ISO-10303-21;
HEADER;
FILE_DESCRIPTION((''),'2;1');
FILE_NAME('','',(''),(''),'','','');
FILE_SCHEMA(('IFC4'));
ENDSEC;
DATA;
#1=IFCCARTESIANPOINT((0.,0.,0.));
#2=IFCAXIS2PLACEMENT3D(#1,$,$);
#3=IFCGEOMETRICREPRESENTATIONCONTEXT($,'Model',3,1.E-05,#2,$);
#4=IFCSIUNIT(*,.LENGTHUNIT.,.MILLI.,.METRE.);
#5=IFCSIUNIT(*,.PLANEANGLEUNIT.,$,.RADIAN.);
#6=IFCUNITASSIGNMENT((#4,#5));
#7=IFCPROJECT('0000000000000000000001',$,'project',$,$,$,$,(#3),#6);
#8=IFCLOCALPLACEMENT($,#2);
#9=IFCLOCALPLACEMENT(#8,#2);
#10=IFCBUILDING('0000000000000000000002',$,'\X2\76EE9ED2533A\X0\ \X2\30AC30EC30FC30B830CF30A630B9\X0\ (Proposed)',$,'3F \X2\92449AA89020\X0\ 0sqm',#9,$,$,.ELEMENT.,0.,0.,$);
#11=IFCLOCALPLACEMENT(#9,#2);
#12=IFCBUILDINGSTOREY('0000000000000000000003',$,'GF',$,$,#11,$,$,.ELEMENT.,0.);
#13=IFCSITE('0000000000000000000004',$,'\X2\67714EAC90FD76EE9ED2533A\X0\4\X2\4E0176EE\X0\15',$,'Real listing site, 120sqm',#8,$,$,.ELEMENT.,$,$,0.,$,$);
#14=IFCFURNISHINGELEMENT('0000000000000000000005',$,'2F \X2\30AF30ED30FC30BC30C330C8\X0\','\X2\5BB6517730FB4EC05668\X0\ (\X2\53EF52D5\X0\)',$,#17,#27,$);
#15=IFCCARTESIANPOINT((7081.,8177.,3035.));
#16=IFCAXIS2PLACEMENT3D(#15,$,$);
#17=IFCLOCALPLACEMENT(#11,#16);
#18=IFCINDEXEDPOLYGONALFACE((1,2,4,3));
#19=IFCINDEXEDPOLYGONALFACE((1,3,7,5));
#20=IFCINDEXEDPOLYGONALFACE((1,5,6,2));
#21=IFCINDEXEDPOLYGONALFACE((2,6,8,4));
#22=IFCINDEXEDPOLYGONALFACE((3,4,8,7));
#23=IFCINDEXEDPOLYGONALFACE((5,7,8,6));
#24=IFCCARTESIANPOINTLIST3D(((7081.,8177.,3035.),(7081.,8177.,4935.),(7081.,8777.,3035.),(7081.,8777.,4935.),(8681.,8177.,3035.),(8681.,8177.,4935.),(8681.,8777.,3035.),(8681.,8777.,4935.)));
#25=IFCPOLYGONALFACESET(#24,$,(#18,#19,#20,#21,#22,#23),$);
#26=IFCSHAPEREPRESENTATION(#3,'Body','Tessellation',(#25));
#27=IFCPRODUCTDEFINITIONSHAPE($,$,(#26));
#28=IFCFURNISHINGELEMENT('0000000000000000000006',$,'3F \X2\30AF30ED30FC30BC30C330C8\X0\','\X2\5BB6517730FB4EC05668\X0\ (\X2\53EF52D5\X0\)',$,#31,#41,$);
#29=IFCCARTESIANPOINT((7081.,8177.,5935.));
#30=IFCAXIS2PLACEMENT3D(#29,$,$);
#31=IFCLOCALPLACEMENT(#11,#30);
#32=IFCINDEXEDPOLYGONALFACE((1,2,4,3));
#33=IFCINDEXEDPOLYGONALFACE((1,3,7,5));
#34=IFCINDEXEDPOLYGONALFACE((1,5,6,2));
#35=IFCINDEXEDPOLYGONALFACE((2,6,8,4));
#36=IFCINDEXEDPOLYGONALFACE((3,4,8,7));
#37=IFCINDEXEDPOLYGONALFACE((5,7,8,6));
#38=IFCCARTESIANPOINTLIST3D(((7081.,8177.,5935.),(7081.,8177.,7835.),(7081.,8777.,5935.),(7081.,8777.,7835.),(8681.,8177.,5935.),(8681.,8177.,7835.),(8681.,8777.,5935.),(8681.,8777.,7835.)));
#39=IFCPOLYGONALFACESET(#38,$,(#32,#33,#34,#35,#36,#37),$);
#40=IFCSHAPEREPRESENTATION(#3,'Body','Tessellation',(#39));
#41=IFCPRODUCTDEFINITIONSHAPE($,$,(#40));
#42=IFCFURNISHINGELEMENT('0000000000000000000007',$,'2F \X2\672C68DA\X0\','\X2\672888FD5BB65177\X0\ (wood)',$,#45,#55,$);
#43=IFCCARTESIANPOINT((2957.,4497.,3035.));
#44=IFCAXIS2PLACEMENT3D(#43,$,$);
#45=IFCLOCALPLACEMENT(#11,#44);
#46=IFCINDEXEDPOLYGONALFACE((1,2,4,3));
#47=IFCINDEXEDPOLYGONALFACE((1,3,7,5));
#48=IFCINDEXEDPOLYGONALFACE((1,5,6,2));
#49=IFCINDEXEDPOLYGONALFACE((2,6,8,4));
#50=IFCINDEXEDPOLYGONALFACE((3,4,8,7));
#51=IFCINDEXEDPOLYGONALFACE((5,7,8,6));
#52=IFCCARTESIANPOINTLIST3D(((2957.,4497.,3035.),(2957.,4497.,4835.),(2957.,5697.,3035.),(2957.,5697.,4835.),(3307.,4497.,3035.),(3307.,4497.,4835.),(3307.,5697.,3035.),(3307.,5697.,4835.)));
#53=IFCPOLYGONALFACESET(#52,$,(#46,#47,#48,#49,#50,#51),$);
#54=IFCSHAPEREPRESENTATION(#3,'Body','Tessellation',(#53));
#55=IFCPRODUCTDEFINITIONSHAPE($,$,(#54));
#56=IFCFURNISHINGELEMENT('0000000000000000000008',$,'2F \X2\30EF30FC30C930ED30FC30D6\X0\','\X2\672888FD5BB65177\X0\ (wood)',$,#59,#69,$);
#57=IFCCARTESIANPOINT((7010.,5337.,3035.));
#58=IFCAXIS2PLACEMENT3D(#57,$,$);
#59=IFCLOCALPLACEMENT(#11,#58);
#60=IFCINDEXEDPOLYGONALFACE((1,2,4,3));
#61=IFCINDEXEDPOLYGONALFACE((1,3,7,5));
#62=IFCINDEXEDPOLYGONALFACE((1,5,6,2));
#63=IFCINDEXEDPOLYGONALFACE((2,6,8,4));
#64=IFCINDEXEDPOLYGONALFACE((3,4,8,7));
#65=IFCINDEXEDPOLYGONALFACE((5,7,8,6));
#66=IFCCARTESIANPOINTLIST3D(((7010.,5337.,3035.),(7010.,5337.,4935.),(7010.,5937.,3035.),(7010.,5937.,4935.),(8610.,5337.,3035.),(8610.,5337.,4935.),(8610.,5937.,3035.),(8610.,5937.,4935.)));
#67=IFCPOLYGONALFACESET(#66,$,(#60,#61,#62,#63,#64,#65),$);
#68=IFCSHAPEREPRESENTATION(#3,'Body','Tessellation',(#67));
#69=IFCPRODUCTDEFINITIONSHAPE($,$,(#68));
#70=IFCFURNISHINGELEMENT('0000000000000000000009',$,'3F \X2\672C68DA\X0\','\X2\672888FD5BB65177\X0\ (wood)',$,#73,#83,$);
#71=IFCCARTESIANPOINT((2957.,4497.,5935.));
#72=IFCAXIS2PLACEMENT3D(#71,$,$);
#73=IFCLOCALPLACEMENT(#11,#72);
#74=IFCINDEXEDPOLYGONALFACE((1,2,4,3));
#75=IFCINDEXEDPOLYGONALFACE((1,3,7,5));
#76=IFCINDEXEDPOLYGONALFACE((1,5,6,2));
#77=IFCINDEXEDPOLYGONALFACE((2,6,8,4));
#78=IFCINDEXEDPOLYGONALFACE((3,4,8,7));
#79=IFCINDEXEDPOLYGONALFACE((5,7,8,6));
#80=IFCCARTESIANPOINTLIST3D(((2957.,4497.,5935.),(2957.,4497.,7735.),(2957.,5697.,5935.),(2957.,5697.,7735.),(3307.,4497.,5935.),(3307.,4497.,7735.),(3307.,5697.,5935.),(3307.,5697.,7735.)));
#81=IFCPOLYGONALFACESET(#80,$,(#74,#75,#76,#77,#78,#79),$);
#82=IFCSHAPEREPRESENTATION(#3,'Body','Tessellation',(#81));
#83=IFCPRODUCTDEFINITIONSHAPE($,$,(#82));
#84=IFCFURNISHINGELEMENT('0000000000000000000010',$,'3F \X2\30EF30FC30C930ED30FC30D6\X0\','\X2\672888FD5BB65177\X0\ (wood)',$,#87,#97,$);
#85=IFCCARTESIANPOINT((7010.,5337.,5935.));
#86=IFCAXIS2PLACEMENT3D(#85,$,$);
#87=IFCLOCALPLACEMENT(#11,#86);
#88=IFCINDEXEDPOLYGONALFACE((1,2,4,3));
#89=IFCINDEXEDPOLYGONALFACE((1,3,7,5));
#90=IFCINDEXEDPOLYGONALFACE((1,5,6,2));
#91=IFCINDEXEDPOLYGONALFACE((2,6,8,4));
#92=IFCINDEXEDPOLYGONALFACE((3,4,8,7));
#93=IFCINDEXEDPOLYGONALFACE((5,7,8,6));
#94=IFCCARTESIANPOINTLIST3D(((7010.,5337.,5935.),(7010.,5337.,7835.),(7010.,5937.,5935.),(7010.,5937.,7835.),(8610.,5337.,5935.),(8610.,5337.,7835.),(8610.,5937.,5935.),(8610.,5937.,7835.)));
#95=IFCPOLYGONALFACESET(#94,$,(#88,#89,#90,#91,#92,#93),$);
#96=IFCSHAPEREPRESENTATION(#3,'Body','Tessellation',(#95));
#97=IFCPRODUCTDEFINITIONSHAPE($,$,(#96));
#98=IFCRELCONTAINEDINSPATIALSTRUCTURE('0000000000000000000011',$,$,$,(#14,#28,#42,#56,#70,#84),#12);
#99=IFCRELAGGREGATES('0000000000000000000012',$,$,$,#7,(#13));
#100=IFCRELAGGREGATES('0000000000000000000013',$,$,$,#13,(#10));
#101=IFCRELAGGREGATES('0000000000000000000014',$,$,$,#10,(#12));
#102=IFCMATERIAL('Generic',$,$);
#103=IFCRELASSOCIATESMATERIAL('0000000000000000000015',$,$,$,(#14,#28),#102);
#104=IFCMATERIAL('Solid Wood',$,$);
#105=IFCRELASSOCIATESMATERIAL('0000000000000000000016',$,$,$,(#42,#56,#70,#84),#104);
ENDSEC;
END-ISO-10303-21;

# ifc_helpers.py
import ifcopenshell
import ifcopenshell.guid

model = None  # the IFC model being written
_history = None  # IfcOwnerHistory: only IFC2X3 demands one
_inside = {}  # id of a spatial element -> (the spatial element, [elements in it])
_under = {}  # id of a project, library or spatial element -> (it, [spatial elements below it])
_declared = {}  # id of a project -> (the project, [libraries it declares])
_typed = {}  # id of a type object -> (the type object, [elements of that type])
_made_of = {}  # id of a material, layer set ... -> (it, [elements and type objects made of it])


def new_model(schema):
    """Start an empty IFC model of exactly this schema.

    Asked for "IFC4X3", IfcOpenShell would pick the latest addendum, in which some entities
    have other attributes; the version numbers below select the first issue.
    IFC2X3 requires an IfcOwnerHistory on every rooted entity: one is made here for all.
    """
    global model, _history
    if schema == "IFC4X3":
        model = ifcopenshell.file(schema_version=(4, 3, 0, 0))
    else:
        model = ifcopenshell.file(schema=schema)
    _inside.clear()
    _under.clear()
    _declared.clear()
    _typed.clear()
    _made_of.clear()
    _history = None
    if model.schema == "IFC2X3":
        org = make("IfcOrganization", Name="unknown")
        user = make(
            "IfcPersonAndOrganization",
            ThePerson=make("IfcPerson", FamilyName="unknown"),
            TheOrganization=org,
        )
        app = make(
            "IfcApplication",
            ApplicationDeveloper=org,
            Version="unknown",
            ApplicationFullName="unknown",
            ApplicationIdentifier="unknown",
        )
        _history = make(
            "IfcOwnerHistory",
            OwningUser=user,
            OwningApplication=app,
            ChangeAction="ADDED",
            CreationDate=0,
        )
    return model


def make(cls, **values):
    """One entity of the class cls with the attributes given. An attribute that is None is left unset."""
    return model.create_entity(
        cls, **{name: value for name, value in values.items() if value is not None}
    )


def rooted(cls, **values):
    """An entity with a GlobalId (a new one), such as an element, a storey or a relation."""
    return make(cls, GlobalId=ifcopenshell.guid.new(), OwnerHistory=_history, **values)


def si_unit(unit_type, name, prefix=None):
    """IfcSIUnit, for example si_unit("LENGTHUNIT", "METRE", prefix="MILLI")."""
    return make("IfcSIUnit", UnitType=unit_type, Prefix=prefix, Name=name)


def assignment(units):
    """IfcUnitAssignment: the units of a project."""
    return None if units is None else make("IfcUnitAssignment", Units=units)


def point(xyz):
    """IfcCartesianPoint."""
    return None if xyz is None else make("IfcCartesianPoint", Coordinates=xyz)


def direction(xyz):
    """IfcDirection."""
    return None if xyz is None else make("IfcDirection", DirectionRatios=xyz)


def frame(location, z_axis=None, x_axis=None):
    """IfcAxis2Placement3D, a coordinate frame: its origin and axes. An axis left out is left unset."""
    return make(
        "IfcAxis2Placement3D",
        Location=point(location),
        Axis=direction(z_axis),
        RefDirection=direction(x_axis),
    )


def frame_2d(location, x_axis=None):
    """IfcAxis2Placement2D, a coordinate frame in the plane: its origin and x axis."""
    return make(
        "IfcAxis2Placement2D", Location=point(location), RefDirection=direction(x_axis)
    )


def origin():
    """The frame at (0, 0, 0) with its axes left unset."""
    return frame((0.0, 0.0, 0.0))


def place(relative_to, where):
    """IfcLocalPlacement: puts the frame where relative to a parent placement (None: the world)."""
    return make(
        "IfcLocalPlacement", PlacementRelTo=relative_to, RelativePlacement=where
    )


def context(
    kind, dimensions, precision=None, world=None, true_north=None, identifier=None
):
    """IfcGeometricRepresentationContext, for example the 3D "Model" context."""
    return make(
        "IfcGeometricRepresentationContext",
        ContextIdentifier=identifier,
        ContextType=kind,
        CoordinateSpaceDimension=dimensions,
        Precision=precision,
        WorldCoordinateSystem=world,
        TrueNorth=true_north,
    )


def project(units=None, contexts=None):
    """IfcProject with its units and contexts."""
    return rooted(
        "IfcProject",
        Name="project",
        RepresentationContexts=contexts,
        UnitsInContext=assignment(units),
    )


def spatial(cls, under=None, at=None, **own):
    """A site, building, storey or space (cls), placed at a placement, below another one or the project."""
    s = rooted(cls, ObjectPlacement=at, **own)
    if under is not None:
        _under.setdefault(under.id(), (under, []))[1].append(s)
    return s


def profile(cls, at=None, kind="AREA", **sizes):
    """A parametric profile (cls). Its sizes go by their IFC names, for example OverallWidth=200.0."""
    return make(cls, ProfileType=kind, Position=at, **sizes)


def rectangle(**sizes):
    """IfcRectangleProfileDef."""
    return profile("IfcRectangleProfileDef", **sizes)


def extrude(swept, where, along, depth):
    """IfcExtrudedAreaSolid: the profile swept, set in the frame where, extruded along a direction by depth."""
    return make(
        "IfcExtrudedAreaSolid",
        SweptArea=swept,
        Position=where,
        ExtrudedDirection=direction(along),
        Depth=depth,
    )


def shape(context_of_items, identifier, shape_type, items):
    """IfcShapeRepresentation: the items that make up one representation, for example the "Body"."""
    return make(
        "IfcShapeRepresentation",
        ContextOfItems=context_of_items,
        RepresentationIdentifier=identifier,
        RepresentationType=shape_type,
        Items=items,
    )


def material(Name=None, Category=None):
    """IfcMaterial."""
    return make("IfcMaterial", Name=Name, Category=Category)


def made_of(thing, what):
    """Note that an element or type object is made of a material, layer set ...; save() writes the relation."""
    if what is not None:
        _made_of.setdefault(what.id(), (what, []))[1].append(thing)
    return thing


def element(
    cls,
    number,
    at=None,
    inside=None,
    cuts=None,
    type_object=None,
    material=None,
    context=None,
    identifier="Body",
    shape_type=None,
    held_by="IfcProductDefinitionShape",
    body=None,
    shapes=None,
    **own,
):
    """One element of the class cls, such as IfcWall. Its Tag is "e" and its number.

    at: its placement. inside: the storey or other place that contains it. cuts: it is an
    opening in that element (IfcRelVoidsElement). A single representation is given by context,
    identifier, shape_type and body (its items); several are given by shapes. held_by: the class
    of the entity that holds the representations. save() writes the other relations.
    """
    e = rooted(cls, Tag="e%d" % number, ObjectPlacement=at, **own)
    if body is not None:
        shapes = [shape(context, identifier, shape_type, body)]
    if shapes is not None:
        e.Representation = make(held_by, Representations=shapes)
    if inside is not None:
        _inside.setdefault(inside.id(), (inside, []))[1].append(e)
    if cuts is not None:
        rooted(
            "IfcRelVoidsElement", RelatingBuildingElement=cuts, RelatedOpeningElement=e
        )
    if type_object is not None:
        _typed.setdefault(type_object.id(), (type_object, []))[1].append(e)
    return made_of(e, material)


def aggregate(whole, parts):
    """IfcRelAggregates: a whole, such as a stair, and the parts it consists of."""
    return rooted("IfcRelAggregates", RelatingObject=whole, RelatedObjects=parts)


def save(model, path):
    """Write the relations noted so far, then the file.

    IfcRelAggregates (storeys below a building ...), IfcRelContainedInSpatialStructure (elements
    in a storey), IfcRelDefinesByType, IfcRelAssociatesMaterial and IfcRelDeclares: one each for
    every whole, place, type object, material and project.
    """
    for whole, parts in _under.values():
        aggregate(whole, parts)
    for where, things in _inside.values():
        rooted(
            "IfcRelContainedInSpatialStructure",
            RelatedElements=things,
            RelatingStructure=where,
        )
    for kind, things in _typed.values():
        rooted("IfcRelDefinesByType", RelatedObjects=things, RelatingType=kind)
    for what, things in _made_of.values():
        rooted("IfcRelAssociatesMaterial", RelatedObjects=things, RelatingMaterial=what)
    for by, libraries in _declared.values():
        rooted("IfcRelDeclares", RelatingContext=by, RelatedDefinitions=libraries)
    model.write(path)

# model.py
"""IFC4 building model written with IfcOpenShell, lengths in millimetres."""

from ifc_helpers import new_model, si_unit, frame, frame_2d, origin, place, context, project, spatial, rectangle, extrude, material, element, save


model = new_model("IFC4")

# Units and contexts
model_context = context("Model", 3, precision=1e-05, world=origin())
ifc_project = project(units=[si_unit("LENGTHUNIT", "METRE", prefix="MILLI"), si_unit("PLANEANGLEUNIT", "RADIAN")], contexts=[model_context])

# Site, building, storey
site_placement = place(None, origin())
site = spatial("IfcSite", under=ifc_project, at=site_placement, Name="東京都目黒区4丁目15", ObjectType="Real listing site, 120sqm", CompositionType="ELEMENT", RefElevation=0.0)
building_placement = place(site_placement, origin())
building = spatial("IfcBuilding", under=site, at=building_placement, Name="目黒区 ガレージハウス (Proposed)", ObjectType="3F 鉄骨造 0sqm", CompositionType="ELEMENT", ElevationOfRefHeight=0.0, ElevationOfTerrain=0.0)
storey_placement = place(building_placement, origin())
storey = spatial("IfcBuildingStorey", under=building, at=storey_placement, Name="GF", CompositionType="ELEMENT", Elevation=0.0)

# Shared definitions
ifc_material_1 = material(Name="Solid Wood")

# Shared definitions
ifc_material_2 = material(Name="Generic")

# Furnishing elements
furnishing_1_placement = place(storey_placement, frame((7081.0, 8177.0, 3035.0)))
element("IfcFurnishingElement", 1, at=furnishing_1_placement, inside=storey, material=ifc_material_2, Name="2F クローゼット", Description="家具・什器 (可動)", context=model_context, shape_type="SweptSolid", body=[
    extrude(rectangle(XDim=1600.0, YDim=600.0, at=frame_2d((800.0, 300.0))), frame((7081.0, 8177.0, 3035.0)), (0.0, 0.0, 1.0), 1900.0),
])
furnishing_2_placement = place(storey_placement, frame((7081.0, 8177.0, 5935.0)))
element("IfcFurnishingElement", 2, at=furnishing_2_placement, inside=storey, material=ifc_material_2, Name="3F クローゼット", Description="家具・什器 (可動)", context=model_context, shape_type="SweptSolid", body=[
    extrude(rectangle(XDim=1600.0, YDim=600.0, at=frame_2d((800.0, 300.0))), frame((7081.0, 8177.0, 5935.0)), (0.0, 0.0, 1.0), 1900.0),
])
furnishing_3_placement = place(storey_placement, frame((2957.0, 4497.0, 3035.0)))
element("IfcFurnishingElement", 3, at=furnishing_3_placement, inside=storey, material=ifc_material_1, Name="2F 本棚", Description="木製家具 (wood)", context=model_context, shape_type="SweptSolid", body=[
    extrude(rectangle(XDim=350.0, YDim=1200.0, at=frame_2d((175.0, 600.0))), frame((2957.0, 4497.0, 3035.0)), (0.0, 0.0, 1.0), 1800.0),
])
furnishing_4_placement = place(storey_placement, frame((7010.0, 5337.0, 3035.0)))
element("IfcFurnishingElement", 4, at=furnishing_4_placement, inside=storey, material=ifc_material_1, Name="2F ワードローブ", Description="木製家具 (wood)", context=model_context, shape_type="SweptSolid", body=[
    extrude(rectangle(XDim=1600.0, YDim=600.0, at=frame_2d((800.0, 300.0))), frame((7010.0, 5337.0, 3035.0)), (0.0, 0.0, 1.0), 1900.0),
])
furnishing_5_placement = place(storey_placement, frame((2957.0, 4497.0, 5935.0)))
element("IfcFurnishingElement", 5, at=furnishing_5_placement, inside=storey, material=ifc_material_1, Name="3F 本棚", Description="木製家具 (wood)", context=model_context, shape_type="SweptSolid", body=[
    extrude(rectangle(XDim=350.0, YDim=1200.0, at=frame_2d((175.0, 600.0))), frame((2957.0, 4497.0, 5935.0)), (0.0, 0.0, 1.0), 1800.0),
])
furnishing_6_placement = place(storey_placement, frame((7010.0, 5337.0, 5935.0)))
element("IfcFurnishingElement", 6, at=furnishing_6_placement, inside=storey, material=ifc_material_1, Name="3F ワードローブ", Description="木製家具 (wood)", context=model_context, shape_type="SweptSolid", body=[
    extrude(rectangle(XDim=1600.0, YDim=600.0, at=frame_2d((800.0, 300.0))), frame((7010.0, 5337.0, 5935.0)), (0.0, 0.0, 1.0), 1900.0),
])

save(model, "model.ifc")
